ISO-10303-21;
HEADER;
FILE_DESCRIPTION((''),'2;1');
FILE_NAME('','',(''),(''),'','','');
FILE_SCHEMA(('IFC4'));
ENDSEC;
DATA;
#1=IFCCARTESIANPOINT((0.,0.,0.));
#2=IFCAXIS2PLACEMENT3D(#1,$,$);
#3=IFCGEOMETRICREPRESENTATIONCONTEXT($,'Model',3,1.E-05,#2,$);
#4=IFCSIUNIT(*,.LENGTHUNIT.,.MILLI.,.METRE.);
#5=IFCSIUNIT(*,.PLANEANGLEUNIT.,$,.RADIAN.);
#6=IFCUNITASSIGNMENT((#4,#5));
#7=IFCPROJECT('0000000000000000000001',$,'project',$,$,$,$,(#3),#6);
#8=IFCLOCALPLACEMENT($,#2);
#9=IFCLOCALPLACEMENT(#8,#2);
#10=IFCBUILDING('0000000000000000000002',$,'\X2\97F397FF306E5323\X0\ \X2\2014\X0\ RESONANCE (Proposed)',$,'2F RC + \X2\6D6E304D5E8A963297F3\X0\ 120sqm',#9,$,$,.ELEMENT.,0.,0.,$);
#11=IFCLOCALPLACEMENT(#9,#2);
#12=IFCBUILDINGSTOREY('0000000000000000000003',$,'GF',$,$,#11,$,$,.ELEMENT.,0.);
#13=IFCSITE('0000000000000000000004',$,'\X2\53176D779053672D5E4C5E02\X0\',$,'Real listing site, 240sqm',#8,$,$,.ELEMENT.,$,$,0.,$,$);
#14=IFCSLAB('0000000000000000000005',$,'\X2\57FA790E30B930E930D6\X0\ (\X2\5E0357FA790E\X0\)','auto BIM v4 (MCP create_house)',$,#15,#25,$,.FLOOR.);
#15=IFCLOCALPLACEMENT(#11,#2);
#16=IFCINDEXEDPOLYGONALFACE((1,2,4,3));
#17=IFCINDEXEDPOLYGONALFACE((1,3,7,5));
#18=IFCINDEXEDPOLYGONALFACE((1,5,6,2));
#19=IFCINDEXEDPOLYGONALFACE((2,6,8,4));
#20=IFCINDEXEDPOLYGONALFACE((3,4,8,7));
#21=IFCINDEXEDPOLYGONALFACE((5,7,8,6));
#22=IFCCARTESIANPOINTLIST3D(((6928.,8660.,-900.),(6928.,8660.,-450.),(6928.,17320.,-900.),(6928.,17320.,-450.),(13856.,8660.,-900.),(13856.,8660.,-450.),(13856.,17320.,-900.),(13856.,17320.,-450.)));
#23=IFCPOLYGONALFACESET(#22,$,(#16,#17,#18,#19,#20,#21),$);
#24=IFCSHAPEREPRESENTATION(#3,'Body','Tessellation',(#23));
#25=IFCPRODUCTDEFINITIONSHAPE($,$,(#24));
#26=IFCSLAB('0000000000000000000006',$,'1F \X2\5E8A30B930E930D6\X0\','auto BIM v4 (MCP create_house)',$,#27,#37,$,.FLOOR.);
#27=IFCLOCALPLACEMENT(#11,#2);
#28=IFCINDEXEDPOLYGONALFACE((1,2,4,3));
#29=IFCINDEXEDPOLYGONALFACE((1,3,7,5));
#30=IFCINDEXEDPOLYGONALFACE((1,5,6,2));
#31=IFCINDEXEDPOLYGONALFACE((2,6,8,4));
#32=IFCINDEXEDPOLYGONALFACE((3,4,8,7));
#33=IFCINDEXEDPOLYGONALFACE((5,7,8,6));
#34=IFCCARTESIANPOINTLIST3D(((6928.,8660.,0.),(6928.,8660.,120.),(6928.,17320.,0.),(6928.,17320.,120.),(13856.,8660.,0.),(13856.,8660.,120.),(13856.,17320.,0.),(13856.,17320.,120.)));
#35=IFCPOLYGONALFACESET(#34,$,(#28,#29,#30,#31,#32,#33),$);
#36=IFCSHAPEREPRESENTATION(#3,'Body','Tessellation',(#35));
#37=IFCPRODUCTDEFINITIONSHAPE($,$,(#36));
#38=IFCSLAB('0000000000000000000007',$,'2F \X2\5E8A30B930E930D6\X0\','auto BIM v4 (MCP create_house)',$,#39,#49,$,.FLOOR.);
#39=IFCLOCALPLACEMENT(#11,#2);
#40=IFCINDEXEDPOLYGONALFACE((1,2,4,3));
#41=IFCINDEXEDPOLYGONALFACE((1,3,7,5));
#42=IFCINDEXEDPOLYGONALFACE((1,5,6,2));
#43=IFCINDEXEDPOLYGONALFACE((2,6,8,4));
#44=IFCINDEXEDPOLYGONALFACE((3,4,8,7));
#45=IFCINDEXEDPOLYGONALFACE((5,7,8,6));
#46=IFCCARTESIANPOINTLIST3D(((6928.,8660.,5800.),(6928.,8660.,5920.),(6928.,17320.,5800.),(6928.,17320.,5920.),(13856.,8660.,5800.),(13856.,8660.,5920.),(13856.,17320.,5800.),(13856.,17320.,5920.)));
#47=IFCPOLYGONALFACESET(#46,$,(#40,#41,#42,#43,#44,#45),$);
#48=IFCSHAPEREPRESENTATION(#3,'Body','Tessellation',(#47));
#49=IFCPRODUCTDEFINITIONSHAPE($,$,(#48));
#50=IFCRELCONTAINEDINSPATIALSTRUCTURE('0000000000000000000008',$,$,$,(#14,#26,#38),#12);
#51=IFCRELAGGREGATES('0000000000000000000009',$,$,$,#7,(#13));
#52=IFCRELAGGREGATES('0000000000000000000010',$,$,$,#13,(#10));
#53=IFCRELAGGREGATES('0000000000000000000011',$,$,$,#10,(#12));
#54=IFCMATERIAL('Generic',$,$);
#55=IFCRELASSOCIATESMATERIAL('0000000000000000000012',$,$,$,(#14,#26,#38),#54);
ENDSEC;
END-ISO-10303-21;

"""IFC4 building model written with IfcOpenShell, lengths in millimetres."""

from ifc_helpers import new_model, si_unit, frame, frame_2d, origin, place, context, project, spatial, rectangle, extrude, material, element, save


model = new_model("IFC4")

# Units and contexts
model_context = context("Model", 3, precision=1e-05, world=origin())
ifc_project = project(units=[si_unit("LENGTHUNIT", "METRE", prefix="MILLI"), si_unit("PLANEANGLEUNIT", "RADIAN")], contexts=[model_context])

# Site, building, storey
site_placement = place(None, origin())
site = spatial("IfcSite", under=ifc_project, at=site_placement, Name="北海道札幌市", ObjectType="Real listing site, 240sqm", CompositionType="ELEMENT", RefElevation=0.0)
building_placement = place(site_placement, origin())
building = spatial("IfcBuilding", under=site, at=building_placement, Name="音響の匣 — RESONANCE (Proposed)", ObjectType="2F RC + 浮き床防音 120sqm", CompositionType="ELEMENT", ElevationOfRefHeight=0.0, ElevationOfTerrain=0.0)
storey_placement = place(building_placement, origin())
storey = spatial("IfcBuildingStorey", under=building, at=storey_placement, Name="GF", CompositionType="ELEMENT", Elevation=0.0)

# Slabs
ifc_material = material(Name="Generic")
slab_1_placement = place(storey_placement, frame((3464.0, 4330.0, -450.0)))
element("IfcSlab", 1, at=slab_1_placement, inside=storey, material=ifc_material, Name="基礎スラブ (布基礎)", Description="auto BIM v4 (MCP create_house)", PredefinedType="FLOOR", context=model_context, shape_type="SweptSolid", body=[
    extrude(rectangle(XDim=6928.0, YDim=8660.0, at=frame_2d((3464.0, 4330.0))), frame((3464.0, 4330.0, -450.0)), (0.0, 0.0, 1.0), 450.0),
])
slab_2_placement = place(storey_placement, frame((3464.0, 4330.0, 0.0)))
element("IfcSlab", 2, at=slab_2_placement, inside=storey, material=ifc_material, Name="1F 床スラブ", Description="auto BIM v4 (MCP create_house)", PredefinedType="FLOOR", context=model_context, shape_type="SweptSolid", body=[
    extrude(rectangle(XDim=6928.0, YDim=8660.0, at=frame_2d((3464.0, 4330.0))), frame((3464.0, 4330.0, 0.0)), (0.0, 0.0, 1.0), 120.0),
])
slab_3_placement = place(storey_placement, frame((3464.0, 4330.0, 2900.0)))
element("IfcSlab", 3, at=slab_3_placement, inside=storey, material=ifc_material, Name="2F 床スラブ", Description="auto BIM v4 (MCP create_house)", PredefinedType="FLOOR", context=model_context, shape_type="SweptSolid", body=[
    extrude(rectangle(XDim=6928.0, YDim=8660.0, at=frame_2d((3464.0, 4330.0))), frame((3464.0, 4330.0, 2900.0)), (0.0, 0.0, 1.0), 120.0),
])

save(model, "model.ifc")
